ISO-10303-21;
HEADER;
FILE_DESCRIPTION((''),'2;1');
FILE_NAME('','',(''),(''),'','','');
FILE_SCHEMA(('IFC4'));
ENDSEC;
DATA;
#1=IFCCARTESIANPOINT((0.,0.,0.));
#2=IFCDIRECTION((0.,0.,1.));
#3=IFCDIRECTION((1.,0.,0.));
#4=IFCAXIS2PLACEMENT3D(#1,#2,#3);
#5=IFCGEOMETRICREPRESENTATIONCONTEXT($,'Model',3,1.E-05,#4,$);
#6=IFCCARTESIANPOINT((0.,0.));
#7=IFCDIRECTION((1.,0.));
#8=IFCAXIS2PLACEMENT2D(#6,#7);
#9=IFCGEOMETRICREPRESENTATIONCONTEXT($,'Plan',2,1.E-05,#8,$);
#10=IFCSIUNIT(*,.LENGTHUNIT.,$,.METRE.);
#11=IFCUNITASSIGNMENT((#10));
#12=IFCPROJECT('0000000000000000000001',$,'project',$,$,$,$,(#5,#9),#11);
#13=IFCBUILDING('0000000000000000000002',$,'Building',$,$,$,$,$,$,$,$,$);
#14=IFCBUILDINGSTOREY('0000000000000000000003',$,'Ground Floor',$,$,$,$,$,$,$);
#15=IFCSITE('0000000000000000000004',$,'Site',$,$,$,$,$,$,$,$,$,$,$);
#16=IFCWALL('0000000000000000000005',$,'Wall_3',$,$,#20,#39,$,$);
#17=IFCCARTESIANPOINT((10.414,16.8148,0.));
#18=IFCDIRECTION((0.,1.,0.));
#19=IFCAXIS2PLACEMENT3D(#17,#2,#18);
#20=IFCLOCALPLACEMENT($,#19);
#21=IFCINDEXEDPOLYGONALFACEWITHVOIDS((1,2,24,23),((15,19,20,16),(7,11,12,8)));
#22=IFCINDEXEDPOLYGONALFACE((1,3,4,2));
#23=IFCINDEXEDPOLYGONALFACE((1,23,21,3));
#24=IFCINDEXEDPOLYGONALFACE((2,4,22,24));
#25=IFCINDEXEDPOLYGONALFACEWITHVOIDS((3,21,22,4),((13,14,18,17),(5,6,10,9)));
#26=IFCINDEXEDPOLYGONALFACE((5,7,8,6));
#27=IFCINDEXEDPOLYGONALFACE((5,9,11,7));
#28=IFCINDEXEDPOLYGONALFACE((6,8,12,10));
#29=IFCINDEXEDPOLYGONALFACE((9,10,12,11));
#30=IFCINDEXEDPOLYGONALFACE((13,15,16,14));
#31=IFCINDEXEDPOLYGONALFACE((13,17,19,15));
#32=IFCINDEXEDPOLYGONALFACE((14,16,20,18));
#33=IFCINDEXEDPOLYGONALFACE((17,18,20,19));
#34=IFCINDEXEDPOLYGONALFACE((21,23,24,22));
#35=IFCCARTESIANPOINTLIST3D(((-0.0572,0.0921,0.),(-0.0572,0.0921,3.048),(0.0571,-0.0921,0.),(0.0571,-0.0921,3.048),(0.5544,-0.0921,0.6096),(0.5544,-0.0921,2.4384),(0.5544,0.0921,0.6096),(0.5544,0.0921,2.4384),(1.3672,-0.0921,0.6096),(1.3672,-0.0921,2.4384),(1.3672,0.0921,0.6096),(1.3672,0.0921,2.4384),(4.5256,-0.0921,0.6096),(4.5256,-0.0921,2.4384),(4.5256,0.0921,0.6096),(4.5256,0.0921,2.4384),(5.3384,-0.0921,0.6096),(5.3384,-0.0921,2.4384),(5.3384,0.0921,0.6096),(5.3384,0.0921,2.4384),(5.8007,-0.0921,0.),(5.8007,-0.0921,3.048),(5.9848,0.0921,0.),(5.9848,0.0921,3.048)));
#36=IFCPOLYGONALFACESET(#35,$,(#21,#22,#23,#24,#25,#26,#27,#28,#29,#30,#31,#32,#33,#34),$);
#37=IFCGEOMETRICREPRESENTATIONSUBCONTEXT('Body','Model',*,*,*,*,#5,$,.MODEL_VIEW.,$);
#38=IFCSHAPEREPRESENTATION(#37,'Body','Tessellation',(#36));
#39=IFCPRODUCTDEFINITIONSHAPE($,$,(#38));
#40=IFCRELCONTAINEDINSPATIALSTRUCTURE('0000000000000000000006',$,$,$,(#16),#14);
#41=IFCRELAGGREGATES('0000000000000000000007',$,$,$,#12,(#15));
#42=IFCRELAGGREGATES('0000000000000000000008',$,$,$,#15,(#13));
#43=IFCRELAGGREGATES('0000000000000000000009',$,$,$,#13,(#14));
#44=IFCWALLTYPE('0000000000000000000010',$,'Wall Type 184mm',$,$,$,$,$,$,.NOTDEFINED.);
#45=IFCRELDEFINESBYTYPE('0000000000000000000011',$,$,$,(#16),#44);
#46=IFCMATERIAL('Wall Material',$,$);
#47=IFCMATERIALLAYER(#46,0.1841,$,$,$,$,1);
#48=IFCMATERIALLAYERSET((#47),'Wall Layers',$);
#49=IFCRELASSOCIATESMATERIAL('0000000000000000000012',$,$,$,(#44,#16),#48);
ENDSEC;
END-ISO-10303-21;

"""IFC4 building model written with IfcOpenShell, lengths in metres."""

from ifc_helpers import new_model, si_unit, frame, origin_with_axes, origin_2d_with_axis, place, context, subcontext, project, spatial, line, indexed_curve, rectangle, outline, extrude, material, layer, layer_set, layer_usage, type_object, element, save


model = new_model("IFC4")

# Units and contexts
model_context = context("Model", 3, precision=1e-05, world=origin_with_axes())
plan_context = context("Plan", 2, precision=1e-05, world=origin_2d_with_axis())
body_context = subcontext(model_context, "Body", "Model", "MODEL_VIEW")
ifc_project = project(units=[si_unit("LENGTHUNIT", "METRE")], contexts=[model_context, plan_context])

# Site, building, storey
site = spatial("IfcSite", under=ifc_project, Name="Site")
building = spatial("IfcBuilding", under=site, Name="Building")
storey = spatial("IfcBuildingStorey", under=building, Name="Ground Floor")

# Shared definitions
ifc_material_1 = material(Name="Wall Material")
ifc_layer_1 = layer(ifc_material_1, 0.1841, Priority=1)
ifc_layer_set_1 = layer_set([ifc_layer_1], Name="Wall Layers")
wall_type_1 = type_object("IfcWallType", Name="Wall Type 184mm", PredefinedType="NOTDEFINED", material=ifc_layer_set_1)

# Wall, openings
ifc_layer_usage_1 = layer_usage(ifc_layer_set_1, "AXIS2", "POSITIVE", -0.0921)
wall_1_placement = place(None, frame((10.414, 16.8148, 0.0), z_axis=(0.0, 0.0, 1.0), x_axis=(0.0, 1.0, 0.0)))
wall_1 = element("IfcWall", 1, at=wall_1_placement, inside=storey, type_object=wall_type_1, material=ifc_layer_usage_1, Name="Wall_3", context=body_context, shape_type="SweptSolid", body=[
    extrude(outline(indexed_curve([(0.0572, -0.0921), (-0.0572, 0.0921), (5.9849, 0.0921), (5.8008, -0.0921)], segments=[line(1, 2, 3, 4, 1)])), origin_with_axes(), (0.0, 0.0, 1.0), 3.048),
])
opening_1_placement = place(wall_1_placement, frame((0.9608, 0.0, 0.6096), z_axis=(0.0, 0.0, 1.0), x_axis=(1.0, 0.0, 0.0)))
element("IfcOpeningElement", 2, at=opening_1_placement, cuts=wall_1, context=body_context, shape_type="SweptSolid", body=[
    extrude(rectangle(XDim=0.8128, YDim=0.5524), None, (0.0, 0.0, 1.0), 1.8288),
])
opening_2_placement = place(wall_1_placement, frame((4.932, 0.0, 0.6096), z_axis=(0.0, 0.0, 1.0), x_axis=(1.0, 0.0, 0.0)))
element("IfcOpeningElement", 3, at=opening_2_placement, cuts=wall_1, context=body_context, shape_type="SweptSolid", body=[
    extrude(rectangle(XDim=0.8128, YDim=0.5524), None, (0.0, 0.0, 1.0), 1.8288),
])

save(model, "model.ifc")
